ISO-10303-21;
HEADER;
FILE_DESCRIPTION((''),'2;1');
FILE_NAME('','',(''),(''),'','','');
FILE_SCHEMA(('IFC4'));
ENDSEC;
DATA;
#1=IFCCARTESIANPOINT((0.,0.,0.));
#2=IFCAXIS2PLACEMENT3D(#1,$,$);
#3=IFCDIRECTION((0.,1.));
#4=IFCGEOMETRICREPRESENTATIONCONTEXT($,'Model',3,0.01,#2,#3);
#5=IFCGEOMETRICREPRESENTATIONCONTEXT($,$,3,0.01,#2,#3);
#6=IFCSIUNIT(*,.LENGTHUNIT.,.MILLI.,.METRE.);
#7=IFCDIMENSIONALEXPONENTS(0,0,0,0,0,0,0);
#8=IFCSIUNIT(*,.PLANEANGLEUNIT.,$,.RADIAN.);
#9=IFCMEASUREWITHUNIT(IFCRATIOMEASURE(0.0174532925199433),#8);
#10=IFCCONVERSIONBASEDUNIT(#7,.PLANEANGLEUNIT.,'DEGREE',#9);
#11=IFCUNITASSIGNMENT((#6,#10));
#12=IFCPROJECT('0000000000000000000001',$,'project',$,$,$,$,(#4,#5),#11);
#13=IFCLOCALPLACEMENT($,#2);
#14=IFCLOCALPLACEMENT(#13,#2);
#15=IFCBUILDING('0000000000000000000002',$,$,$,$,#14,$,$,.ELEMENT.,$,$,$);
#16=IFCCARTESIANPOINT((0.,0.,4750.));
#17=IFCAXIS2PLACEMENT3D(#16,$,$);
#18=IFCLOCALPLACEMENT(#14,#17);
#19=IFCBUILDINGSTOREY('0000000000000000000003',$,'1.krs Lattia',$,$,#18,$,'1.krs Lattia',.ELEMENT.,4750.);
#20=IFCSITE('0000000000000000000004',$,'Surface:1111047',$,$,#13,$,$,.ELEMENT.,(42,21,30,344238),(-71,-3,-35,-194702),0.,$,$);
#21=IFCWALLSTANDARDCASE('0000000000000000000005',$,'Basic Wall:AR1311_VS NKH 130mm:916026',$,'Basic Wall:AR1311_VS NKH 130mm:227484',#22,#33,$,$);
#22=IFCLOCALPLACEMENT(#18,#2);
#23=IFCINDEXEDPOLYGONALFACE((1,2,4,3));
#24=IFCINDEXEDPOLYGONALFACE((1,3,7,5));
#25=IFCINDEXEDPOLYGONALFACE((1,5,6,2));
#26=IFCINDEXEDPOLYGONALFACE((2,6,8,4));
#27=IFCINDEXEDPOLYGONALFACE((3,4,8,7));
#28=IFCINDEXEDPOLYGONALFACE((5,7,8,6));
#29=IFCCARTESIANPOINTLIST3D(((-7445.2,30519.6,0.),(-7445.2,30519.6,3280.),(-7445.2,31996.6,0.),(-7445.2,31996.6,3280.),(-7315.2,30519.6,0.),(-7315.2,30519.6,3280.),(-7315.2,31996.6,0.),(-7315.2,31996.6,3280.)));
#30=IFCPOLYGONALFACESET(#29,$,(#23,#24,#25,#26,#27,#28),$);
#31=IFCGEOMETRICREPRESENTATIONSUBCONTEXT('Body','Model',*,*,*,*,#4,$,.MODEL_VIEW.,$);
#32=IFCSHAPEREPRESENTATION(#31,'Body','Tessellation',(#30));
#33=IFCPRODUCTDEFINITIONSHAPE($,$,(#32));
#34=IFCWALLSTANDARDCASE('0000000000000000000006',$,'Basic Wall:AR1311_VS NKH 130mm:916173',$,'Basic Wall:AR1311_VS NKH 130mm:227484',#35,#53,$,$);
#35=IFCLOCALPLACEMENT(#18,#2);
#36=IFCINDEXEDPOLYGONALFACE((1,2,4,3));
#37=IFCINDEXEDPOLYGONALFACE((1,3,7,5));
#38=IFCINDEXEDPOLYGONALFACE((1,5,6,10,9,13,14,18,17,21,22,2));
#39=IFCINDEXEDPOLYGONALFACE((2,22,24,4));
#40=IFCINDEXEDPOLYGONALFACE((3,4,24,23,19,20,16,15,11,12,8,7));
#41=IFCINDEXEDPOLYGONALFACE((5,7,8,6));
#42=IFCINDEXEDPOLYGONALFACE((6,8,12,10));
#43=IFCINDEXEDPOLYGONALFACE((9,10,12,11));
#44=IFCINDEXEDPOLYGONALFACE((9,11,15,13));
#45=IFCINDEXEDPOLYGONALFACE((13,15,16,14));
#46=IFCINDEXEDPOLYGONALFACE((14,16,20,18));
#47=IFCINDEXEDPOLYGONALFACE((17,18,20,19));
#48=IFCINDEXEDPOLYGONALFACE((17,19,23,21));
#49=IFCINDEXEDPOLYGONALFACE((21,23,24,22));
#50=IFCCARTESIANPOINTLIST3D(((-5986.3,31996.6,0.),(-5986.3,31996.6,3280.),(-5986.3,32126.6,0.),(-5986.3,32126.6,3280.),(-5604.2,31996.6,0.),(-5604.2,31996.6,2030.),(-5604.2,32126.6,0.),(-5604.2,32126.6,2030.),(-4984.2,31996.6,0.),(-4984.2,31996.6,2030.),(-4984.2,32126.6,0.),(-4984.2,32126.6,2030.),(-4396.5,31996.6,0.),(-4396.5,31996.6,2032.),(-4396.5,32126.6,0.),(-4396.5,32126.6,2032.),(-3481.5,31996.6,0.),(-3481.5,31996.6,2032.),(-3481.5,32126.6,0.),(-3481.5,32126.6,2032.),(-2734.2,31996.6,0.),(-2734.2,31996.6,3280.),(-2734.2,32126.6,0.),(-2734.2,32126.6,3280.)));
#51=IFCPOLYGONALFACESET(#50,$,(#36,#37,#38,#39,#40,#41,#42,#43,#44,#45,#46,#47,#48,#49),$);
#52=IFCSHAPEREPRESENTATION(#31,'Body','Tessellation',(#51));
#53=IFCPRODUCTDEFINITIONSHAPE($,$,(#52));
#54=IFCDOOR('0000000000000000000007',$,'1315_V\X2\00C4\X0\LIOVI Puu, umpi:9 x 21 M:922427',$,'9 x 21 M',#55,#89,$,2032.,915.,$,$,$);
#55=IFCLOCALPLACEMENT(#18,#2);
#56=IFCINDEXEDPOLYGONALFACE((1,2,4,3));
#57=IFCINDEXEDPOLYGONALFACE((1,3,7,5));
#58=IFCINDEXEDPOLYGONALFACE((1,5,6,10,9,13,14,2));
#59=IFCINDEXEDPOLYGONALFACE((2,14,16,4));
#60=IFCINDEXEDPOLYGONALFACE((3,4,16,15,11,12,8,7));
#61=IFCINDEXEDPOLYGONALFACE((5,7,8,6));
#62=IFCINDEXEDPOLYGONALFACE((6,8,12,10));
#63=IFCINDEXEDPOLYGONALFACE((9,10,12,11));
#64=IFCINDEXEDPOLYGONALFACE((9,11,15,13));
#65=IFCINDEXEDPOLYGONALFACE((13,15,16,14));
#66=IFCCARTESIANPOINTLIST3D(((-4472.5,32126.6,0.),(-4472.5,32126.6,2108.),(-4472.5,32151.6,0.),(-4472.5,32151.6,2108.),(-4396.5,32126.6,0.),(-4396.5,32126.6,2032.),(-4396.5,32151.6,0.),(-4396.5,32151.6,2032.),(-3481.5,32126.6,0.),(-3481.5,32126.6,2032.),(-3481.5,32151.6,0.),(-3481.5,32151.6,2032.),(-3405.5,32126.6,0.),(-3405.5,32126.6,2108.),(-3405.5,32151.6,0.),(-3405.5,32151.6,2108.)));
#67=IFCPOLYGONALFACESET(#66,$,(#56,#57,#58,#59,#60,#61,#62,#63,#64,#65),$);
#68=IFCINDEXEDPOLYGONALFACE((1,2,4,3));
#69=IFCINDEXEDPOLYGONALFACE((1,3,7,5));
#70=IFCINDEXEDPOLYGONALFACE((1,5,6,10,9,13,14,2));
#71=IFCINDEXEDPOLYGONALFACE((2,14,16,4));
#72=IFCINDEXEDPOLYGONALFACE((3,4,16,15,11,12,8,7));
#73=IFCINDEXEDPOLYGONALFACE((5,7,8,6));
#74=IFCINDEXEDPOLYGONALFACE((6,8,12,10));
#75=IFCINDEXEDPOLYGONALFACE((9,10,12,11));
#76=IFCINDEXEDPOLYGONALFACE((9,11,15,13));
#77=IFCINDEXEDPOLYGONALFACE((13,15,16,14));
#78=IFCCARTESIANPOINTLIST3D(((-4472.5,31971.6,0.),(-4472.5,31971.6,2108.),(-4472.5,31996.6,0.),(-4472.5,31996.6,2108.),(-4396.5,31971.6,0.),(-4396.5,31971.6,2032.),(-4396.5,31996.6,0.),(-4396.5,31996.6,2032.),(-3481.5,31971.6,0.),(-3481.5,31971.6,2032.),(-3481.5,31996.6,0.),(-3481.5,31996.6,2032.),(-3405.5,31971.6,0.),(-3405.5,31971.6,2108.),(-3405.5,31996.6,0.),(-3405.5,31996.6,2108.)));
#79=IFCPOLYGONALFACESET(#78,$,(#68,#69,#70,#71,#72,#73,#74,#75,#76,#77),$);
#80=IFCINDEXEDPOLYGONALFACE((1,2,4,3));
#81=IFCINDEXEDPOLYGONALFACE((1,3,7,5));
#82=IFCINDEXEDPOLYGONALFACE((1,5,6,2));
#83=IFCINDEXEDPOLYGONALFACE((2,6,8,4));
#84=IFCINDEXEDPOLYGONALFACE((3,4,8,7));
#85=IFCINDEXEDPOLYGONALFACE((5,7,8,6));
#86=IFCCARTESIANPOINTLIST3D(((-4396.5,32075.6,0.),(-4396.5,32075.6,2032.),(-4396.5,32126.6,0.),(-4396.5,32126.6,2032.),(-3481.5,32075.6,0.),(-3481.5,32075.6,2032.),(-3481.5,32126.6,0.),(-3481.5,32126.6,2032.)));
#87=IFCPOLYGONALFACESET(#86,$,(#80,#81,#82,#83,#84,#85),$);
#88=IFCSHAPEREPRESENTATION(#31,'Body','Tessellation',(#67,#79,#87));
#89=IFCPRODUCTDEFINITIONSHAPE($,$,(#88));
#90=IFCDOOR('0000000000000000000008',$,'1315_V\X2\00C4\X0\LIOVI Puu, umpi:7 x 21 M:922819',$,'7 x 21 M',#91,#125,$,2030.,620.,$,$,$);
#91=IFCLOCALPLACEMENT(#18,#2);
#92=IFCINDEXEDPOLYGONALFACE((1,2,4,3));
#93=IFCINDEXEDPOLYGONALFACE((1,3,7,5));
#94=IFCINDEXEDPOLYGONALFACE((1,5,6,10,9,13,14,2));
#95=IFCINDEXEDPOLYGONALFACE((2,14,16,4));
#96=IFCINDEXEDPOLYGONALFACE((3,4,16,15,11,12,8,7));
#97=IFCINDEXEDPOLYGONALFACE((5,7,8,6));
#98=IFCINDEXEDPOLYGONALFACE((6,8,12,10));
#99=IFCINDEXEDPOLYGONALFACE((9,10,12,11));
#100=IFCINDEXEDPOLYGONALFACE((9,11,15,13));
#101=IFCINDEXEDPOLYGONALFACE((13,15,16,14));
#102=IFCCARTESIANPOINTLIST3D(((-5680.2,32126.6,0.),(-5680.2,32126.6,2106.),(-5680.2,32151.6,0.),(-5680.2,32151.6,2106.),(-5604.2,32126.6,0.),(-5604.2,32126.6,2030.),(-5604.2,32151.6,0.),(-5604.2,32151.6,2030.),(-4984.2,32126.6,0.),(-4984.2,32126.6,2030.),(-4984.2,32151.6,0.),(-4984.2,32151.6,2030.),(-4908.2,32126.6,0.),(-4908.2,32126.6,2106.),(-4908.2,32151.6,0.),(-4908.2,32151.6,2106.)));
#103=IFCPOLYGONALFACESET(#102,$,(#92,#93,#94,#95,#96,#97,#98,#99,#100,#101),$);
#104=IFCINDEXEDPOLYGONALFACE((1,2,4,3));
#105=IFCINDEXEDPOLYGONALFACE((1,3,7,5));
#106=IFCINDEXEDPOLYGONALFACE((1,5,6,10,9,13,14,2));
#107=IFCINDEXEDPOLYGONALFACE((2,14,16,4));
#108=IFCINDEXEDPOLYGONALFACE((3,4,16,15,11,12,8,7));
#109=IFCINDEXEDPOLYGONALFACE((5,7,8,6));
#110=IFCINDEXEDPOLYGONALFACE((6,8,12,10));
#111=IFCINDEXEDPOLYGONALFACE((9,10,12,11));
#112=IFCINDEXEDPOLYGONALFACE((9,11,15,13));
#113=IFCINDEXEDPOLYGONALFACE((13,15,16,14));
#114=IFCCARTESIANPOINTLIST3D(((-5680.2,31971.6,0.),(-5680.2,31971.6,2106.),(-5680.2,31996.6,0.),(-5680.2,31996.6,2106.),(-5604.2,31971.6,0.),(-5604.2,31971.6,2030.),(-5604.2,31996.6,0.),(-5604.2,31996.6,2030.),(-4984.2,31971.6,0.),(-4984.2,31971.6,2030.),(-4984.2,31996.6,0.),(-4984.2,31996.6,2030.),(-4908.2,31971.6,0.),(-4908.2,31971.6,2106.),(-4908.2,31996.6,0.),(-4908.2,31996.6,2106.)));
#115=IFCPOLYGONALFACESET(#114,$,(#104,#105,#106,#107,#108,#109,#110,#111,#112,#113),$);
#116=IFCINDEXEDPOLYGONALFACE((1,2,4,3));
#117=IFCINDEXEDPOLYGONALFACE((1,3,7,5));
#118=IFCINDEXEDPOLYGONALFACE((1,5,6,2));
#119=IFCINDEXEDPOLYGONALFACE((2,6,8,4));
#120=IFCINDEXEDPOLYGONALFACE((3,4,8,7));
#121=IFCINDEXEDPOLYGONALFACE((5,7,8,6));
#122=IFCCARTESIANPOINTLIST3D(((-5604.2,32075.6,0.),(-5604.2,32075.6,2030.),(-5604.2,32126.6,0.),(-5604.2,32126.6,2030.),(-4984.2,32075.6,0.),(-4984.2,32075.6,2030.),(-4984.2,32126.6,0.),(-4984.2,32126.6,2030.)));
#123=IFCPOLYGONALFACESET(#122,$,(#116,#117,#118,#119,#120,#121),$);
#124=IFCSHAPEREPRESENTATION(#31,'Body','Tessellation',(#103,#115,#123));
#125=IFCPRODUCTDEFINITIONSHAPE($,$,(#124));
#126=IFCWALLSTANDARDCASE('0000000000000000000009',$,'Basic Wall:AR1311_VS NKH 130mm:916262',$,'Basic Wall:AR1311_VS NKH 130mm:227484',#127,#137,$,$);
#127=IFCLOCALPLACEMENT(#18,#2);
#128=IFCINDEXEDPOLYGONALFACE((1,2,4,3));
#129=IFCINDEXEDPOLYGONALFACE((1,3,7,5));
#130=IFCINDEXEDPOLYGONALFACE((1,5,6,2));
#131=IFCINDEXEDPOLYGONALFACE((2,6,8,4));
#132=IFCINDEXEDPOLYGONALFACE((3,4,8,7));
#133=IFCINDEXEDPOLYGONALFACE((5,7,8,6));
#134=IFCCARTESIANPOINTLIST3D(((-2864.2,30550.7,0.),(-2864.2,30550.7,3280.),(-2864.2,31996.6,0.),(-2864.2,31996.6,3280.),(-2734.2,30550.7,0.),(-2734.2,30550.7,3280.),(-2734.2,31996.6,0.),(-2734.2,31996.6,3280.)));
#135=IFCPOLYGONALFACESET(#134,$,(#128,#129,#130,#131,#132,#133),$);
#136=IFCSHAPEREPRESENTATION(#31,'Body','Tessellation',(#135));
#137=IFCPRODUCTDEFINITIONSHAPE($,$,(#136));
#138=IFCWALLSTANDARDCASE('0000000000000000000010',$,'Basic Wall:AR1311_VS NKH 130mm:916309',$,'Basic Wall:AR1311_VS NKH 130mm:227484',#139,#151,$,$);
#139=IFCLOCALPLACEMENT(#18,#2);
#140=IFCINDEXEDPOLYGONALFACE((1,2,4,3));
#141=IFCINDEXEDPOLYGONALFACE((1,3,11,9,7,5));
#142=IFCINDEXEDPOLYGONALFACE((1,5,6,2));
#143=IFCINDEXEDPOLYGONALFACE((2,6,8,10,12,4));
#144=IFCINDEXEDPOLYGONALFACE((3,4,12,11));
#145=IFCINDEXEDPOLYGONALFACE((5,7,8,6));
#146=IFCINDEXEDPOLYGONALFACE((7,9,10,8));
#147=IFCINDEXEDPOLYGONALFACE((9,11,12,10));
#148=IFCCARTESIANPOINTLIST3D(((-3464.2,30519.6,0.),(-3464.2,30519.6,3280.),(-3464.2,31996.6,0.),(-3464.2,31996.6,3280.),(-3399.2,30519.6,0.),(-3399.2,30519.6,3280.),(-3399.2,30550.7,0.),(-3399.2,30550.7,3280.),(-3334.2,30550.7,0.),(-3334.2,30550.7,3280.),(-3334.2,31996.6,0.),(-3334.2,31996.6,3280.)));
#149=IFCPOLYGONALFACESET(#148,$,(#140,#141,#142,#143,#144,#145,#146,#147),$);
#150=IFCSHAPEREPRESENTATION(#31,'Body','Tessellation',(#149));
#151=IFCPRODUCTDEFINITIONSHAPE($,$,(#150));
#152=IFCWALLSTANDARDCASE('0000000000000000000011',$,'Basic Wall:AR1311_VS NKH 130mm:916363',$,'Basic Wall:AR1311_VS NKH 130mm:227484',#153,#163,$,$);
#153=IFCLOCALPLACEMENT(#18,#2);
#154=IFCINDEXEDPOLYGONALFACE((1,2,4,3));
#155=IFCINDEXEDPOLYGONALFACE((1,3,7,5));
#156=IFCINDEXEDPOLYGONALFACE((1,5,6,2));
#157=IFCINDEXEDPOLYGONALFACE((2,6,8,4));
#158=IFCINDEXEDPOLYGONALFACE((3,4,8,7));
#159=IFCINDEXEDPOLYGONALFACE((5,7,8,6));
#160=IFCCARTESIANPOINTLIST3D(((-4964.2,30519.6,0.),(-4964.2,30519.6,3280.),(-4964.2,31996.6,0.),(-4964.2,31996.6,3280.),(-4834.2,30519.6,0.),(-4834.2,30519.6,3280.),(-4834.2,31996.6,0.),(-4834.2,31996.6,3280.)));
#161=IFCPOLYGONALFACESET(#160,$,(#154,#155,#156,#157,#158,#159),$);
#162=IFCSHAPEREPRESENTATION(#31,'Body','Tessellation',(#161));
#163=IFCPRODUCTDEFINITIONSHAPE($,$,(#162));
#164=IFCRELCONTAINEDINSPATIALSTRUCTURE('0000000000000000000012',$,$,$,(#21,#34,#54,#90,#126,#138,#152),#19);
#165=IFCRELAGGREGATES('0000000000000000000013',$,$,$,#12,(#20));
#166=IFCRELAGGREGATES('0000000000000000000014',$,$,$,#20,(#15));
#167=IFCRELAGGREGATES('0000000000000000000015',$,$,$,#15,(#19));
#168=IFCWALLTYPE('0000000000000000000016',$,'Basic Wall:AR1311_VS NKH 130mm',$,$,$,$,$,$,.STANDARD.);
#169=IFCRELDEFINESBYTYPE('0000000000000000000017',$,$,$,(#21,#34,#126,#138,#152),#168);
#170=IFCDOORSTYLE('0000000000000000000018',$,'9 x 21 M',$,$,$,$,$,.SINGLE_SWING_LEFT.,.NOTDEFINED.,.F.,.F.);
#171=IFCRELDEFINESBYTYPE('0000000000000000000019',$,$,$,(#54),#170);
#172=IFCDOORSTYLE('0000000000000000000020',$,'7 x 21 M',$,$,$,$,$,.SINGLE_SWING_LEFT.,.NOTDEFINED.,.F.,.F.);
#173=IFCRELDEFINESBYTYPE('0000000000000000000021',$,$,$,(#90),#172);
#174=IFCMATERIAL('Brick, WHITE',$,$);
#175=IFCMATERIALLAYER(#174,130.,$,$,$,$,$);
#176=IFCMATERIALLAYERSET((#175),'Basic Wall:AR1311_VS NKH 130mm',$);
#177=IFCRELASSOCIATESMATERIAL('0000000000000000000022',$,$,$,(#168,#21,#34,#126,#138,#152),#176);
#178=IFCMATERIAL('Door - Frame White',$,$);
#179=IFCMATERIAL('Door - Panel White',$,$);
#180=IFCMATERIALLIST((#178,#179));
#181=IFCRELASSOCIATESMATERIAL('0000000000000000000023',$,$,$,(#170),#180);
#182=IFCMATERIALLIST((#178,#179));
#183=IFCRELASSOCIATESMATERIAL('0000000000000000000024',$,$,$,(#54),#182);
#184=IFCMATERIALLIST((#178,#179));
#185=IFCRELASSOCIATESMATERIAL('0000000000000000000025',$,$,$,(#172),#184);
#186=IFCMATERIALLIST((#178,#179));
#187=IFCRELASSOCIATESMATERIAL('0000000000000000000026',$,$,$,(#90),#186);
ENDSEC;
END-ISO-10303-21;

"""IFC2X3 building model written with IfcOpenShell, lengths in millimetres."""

from ifc_helpers import new_model, entity, si_unit, converted_unit, direction, frame, frame_2d, origin, place, context, subcontext, project, spatial, polyline, rectangle, outline, extrude, clip, bounded_halfspace, source, transform, mapped, material, material_list, layer, layer_set, layer_usage, type_object, type_shapes, element, fill, save


model = new_model("IFC2X3")

# Units and contexts
model_context = context("Model", 3, precision=0.01, world=origin(), true_north=direction((0.0, 1.0)))
context_of_model = context(None, 3, precision=0.01, world=origin(), true_north=direction((0.0, 1.0)))
body_context = subcontext(model_context, "Body", "Model", "MODEL_VIEW")
ifc_project = project(units=[si_unit("LENGTHUNIT", "METRE", prefix="MILLI"), converted_unit("PLANEANGLEUNIT", "DEGREE", entity("IfcRatioMeasure", 0.0174532925199433), si_unit("PLANEANGLEUNIT", "RADIAN"), dimensions=[0, 0, 0, 0, 0, 0, 0])], contexts=[model_context, context_of_model])

# Site, building, storey
site_placement = place(None, origin())
site = spatial("IfcSite", under=ifc_project, at=site_placement, Name="Surface:1111047", CompositionType="ELEMENT", RefLatitude=(42, 21, 30, 344238), RefLongitude=(-71, -3, -35, -194702), RefElevation=0.0)
building_placement = place(site_placement, origin())
building = spatial("IfcBuilding", under=site, at=building_placement, CompositionType="ELEMENT")
storey_placement = place(building_placement, frame((0.0, 0.0, 4750.0)))
storey = spatial("IfcBuildingStorey", under=building, at=storey_placement, Name="1.krs Lattia", LongName="1.krs Lattia", CompositionType="ELEMENT", Elevation=4750.0)

# Shared definitions
ifc_material_1 = material(Name="Brick, WHITE")
ifc_layer = layer(ifc_material_1, 130.0)
ifc_layer_set = layer_set([ifc_layer], Name="Basic Wall:AR1311_VS NKH 130mm")
wall_type = type_object("IfcWallType", Name="Basic Wall:AR1311_VS NKH 130mm", PredefinedType="STANDARD", material=ifc_layer_set)

# Shared definitions
ifc_material_2 = material(Name="Door - Frame White")
ifc_material_3 = material(Name="Door - Panel White")
ifc_material_list_1 = material_list([ifc_material_2, ifc_material_3])
door_style_1 = type_object("IfcDoorStyle", Name="9 x 21 M", ConstructionType="NOTDEFINED", OperationType="SINGLE_SWING_LEFT", ParameterTakesPrecedence=False, Sizeable=False, material=ifc_material_list_1)
shared_shape_1 = source(origin(), body_context, "Body", "SweptSolid", [
    extrude(outline(polyline([(-533.5, -1073.0), (533.5, -1073.0), (533.5, 1035.0), (457.5, 1035.0), (457.5, -997.0), (-457.5, -997.0), (-457.5, 1035.0), (-533.5, 1035.0), (-533.5, -1073.0)])), frame((457.5, 155.0, 1035.0), z_axis=(0.0, -1.0, 0.0), x_axis=(-1.0, 0.0, 0.0)), (0.0, 0.0, 1.0), 25.0),
    extrude(outline(polyline([(-1073.0, -533.5), (1035.0, -533.5), (1035.0, -457.5), (-997.0, -457.5), (-997.0, 457.5), (1035.0, 457.5), (1035.0, 533.5), (-1073.0, 533.5), (-1073.0, -533.5)])), frame((457.5, 0.0, 1035.0), z_axis=(0.0, -1.0, 0.0), x_axis=(0.0, 0.0, -1.0)), (0.0, 0.0, 1.0), 25.0),
    extrude(rectangle(XDim=915.0, YDim=51.0, at=frame_2d((0.0, 0.0), x_axis=(1.0, 0.0))), frame((457.5, 104.5, 0.0)), (0.0, 0.0, 1.0), 2032.0),
])
type_shapes(door_style_1, [shared_shape_1])

# Wall
ifc_layer_usage_1 = layer_usage(ifc_layer_set, "AXIS2", "NEGATIVE", 65.0)
wall_1_placement = place(storey_placement, frame((-7380.2, 31996.6, 0.0), z_axis=(0.0, 0.0, 1.0), x_axis=(0.0, -1.0, 0.0)))
element("IfcWallStandardCase", 1, at=wall_1_placement, inside=storey, type_object=wall_type, material=ifc_layer_usage_1, Name="Basic Wall:AR1311_VS NKH 130mm:916026", ObjectType="Basic Wall:AR1311_VS NKH 130mm:227484", context=body_context, shape_type="Clipping", body=[
    clip(extrude(rectangle(XDim=1477.0, YDim=130.0, at=frame_2d((738.5, 0.0), x_axis=(-1.0, 0.0))), origin(), (0.0, 0.0, 1.0), 3280.0), bounded_halfspace(frame((0.0, -65.0, 3280.0), z_axis=(0.0, 0.0, -1.0), x_axis=(-1.0, 0.0, 0.0)), True, frame((0.0, -65.0, 3280.0)), polyline([(0.0, 0.0), (1477.0, 0.0), (1477.0, 130.0), (0.0, 130.0), (0.0, 0.0)]))),
])

# Wall, openings, doors
ifc_layer_usage_2 = layer_usage(ifc_layer_set, "AXIS2", "NEGATIVE", 65.0)
wall_2_placement = place(storey_placement, frame((-5986.3, 32061.6, 0.0)))
wall_2 = element("IfcWallStandardCase", 2, at=wall_2_placement, inside=storey, type_object=wall_type, material=ifc_layer_usage_2, Name="Basic Wall:AR1311_VS NKH 130mm:916173", ObjectType="Basic Wall:AR1311_VS NKH 130mm:227484", context=body_context, shape_type="Clipping", body=[
    clip(extrude(rectangle(XDim=3252.1, YDim=130.0, at=frame_2d((1626.0, 0.0), x_axis=(-1.0, 0.0))), origin(), (0.0, 0.0, 1.0), 3280.0), bounded_halfspace(frame((0.0, -65.0, 3280.0), z_axis=(0.0, 0.0, -1.0), x_axis=(0.0, 1.0, 0.0)), True, frame((0.0, -65.0, 3280.0)), polyline([(0.0, 0.0), (1022.1, 0.0), (1152.1, 0.0), (2522.1, 0.0), (2652.1, 0.0), (3122.1, 0.0), (3252.1, 0.0), (3252.1, 130.0), (0.0, 130.0), (0.0, 0.0)]))),
])
opening_1_placement = place(wall_2_placement, frame((1589.7, -65.0, 0.0)))
opening_1 = element("IfcOpeningElement", 3, at=opening_1_placement, cuts=wall_2, ObjectType="Opening", context=body_context, shape_type="SweptSolid", body=[
    extrude(rectangle(XDim=915.0, YDim=2032.0, at=frame_2d((1016.0, 457.5), x_axis=(0.0, -1.0))), frame((0.0, 0.0, 0.0), z_axis=(0.0, 1.0, 0.0), x_axis=(0.0, 0.0, 1.0)), (0.0, 0.0, 1.0), 130.0),
])
opening_2_placement = place(wall_2_placement, frame((382.1, -65.0, 0.0)))
opening_2 = element("IfcOpeningElement", 4, at=opening_2_placement, cuts=wall_2, ObjectType="Opening", context=body_context, shape_type="SweptSolid", body=[
    extrude(rectangle(XDim=620.0, YDim=2030.0, at=frame_2d((1015.0, 310.0), x_axis=(0.0, -1.0))), frame((0.0, 0.0, 0.0), z_axis=(0.0, 1.0, 0.0), x_axis=(0.0, 0.0, 1.0)), (0.0, 0.0, 1.0), 130.0),
])
ifc_material_list_2 = material_list([ifc_material_2, ifc_material_3])
door_1_placement = place(opening_1_placement, origin())
door_1 = element("IfcDoor", 5, at=door_1_placement, inside=storey, type_object=door_style_1, material=ifc_material_list_2, Name="1315_VÄLIOVI Puu, umpi:9 x 21 M:922427", ObjectType="9 x 21 M", OverallHeight=2032.0, OverallWidth=915.0, context=body_context, shape_type="MappedRepresentation", body=[
    mapped(shared_shape_1, transform((0.0, 0.0, 0.0), scale=1.0)),
])
fill(opening_1, door_1)
ifc_material_list_3 = material_list([ifc_material_2, ifc_material_3])
ifc_material_list_4 = material_list([ifc_material_2, ifc_material_3])
door_style_2 = type_object("IfcDoorStyle", Name="7 x 21 M", ConstructionType="NOTDEFINED", OperationType="SINGLE_SWING_LEFT", ParameterTakesPrecedence=False, Sizeable=False, material=ifc_material_list_4)
shared_shape_2 = source(origin(), body_context, "Body", "SweptSolid", [
    extrude(outline(polyline([(-386.0, -1072.0), (386.0, -1072.0), (386.0, 1034.0), (310.0, 1034.0), (310.0, -996.0), (-310.0, -996.0), (-310.0, 1034.0), (-386.0, 1034.0), (-386.0, -1072.0)])), frame((310.0, 155.0, 1034.0), z_axis=(0.0, -1.0, 0.0), x_axis=(-1.0, 0.0, 0.0)), (0.0, 0.0, 1.0), 25.0),
    extrude(outline(polyline([(-1072.0, -386.0), (1034.0, -386.0), (1034.0, -310.0), (-996.0, -310.0), (-996.0, 310.0), (1034.0, 310.0), (1034.0, 386.0), (-1072.0, 386.0), (-1072.0, -386.0)])), frame((310.0, 0.0, 1034.0), z_axis=(0.0, -1.0, 0.0), x_axis=(0.0, 0.0, -1.0)), (0.0, 0.0, 1.0), 25.0),
    extrude(rectangle(XDim=620.0, YDim=51.0, at=frame_2d((0.0, 0.0), x_axis=(1.0, 0.0))), frame((310.0, 104.5, 0.0)), (0.0, 0.0, 1.0), 2030.0),
])
type_shapes(door_style_2, [shared_shape_2])
door_2_placement = place(opening_2_placement, origin())
door_2 = element("IfcDoor", 6, at=door_2_placement, inside=storey, type_object=door_style_2, material=ifc_material_list_3, Name="1315_VÄLIOVI Puu, umpi:7 x 21 M:922819", ObjectType="7 x 21 M", OverallHeight=2030.0, OverallWidth=620.0, context=body_context, shape_type="MappedRepresentation", body=[
    mapped(shared_shape_2, transform((0.0, 0.0, 0.0), scale=1.0)),
])
fill(opening_2, door_2)

# Walls
ifc_layer_usage_3 = layer_usage(ifc_layer_set, "AXIS2", "NEGATIVE", 65.0)
wall_3_placement = place(storey_placement, frame((-2799.2, 31996.6, 0.0), z_axis=(0.0, 0.0, 1.0), x_axis=(0.0, -1.0, 0.0)))
element("IfcWallStandardCase", 7, at=wall_3_placement, inside=storey, type_object=wall_type, material=ifc_layer_usage_3, Name="Basic Wall:AR1311_VS NKH 130mm:916262", ObjectType="Basic Wall:AR1311_VS NKH 130mm:227484", context=body_context, shape_type="Clipping", body=[
    clip(extrude(rectangle(XDim=1445.9, YDim=130.0, at=frame_2d((722.9, 0.0), x_axis=(-1.0, 0.0))), origin(), (0.0, 0.0, 1.0), 3280.0), bounded_halfspace(frame((0.0, -65.0, 3280.0), z_axis=(0.0, 0.0, -1.0), x_axis=(-1.0, 0.0, 0.0)), True, frame((0.0, -65.0, 3280.0)), polyline([(0.0, 0.0), (1445.9, 0.0), (1445.9, 130.0), (0.0, 130.0), (0.0, 0.0)]))),
])
ifc_layer_usage_4 = layer_usage(ifc_layer_set, "AXIS2", "NEGATIVE", 65.0)
wall_4_placement = place(storey_placement, frame((-3399.2, 31996.6, 0.0), z_axis=(0.0, 0.0, 1.0), x_axis=(0.0, -1.0, 0.0)))
element("IfcWallStandardCase", 8, at=wall_4_placement, inside=storey, type_object=wall_type, material=ifc_layer_usage_4, Name="Basic Wall:AR1311_VS NKH 130mm:916309", ObjectType="Basic Wall:AR1311_VS NKH 130mm:227484", context=body_context, shape_type="Clipping", body=[
    clip(extrude(outline(polyline([(1477.0, -65.0), (1477.0, 0.0), (1445.9, 0.0), (1445.9, 65.0), (0.0, 65.0), (0.0, -65.0), (1477.0, -65.0)])), origin(), (0.0, 0.0, 1.0), 3280.0), bounded_halfspace(frame((0.0, -65.0, 3280.0), z_axis=(0.0, 0.0, -1.0), x_axis=(-1.0, 0.0, 0.0)), True, frame((0.0, -65.0, 3280.0)), polyline([(0.0, 0.0), (1477.0, 0.0), (1477.0, 65.0), (1445.9, 65.0), (1445.9, 130.0), (0.0, 130.0), (0.0, 0.0)]))),
])
ifc_layer_usage_5 = layer_usage(ifc_layer_set, "AXIS2", "NEGATIVE", 65.0)
wall_5_placement = place(storey_placement, frame((-4899.2, 31996.6, 0.0), z_axis=(0.0, 0.0, 1.0), x_axis=(0.0, -1.0, 0.0)))
element("IfcWallStandardCase", 9, at=wall_5_placement, inside=storey, type_object=wall_type, material=ifc_layer_usage_5, Name="Basic Wall:AR1311_VS NKH 130mm:916363", ObjectType="Basic Wall:AR1311_VS NKH 130mm:227484", context=body_context, shape_type="Clipping", body=[
    clip(extrude(rectangle(XDim=1477.0, YDim=130.0, at=frame_2d((738.5, 0.0), x_axis=(-1.0, 0.0))), origin(), (0.0, 0.0, 1.0), 3280.0), bounded_halfspace(frame((0.0, -65.0, 3280.0), z_axis=(0.0, 0.0, -1.0), x_axis=(-1.0, 0.0, 0.0)), True, frame((0.0, -65.0, 3280.0)), polyline([(0.0, 0.0), (1477.0, 0.0), (1477.0, 130.0), (0.0, 130.0), (0.0, 0.0)]))),
])

save(model, "model.ifc")
